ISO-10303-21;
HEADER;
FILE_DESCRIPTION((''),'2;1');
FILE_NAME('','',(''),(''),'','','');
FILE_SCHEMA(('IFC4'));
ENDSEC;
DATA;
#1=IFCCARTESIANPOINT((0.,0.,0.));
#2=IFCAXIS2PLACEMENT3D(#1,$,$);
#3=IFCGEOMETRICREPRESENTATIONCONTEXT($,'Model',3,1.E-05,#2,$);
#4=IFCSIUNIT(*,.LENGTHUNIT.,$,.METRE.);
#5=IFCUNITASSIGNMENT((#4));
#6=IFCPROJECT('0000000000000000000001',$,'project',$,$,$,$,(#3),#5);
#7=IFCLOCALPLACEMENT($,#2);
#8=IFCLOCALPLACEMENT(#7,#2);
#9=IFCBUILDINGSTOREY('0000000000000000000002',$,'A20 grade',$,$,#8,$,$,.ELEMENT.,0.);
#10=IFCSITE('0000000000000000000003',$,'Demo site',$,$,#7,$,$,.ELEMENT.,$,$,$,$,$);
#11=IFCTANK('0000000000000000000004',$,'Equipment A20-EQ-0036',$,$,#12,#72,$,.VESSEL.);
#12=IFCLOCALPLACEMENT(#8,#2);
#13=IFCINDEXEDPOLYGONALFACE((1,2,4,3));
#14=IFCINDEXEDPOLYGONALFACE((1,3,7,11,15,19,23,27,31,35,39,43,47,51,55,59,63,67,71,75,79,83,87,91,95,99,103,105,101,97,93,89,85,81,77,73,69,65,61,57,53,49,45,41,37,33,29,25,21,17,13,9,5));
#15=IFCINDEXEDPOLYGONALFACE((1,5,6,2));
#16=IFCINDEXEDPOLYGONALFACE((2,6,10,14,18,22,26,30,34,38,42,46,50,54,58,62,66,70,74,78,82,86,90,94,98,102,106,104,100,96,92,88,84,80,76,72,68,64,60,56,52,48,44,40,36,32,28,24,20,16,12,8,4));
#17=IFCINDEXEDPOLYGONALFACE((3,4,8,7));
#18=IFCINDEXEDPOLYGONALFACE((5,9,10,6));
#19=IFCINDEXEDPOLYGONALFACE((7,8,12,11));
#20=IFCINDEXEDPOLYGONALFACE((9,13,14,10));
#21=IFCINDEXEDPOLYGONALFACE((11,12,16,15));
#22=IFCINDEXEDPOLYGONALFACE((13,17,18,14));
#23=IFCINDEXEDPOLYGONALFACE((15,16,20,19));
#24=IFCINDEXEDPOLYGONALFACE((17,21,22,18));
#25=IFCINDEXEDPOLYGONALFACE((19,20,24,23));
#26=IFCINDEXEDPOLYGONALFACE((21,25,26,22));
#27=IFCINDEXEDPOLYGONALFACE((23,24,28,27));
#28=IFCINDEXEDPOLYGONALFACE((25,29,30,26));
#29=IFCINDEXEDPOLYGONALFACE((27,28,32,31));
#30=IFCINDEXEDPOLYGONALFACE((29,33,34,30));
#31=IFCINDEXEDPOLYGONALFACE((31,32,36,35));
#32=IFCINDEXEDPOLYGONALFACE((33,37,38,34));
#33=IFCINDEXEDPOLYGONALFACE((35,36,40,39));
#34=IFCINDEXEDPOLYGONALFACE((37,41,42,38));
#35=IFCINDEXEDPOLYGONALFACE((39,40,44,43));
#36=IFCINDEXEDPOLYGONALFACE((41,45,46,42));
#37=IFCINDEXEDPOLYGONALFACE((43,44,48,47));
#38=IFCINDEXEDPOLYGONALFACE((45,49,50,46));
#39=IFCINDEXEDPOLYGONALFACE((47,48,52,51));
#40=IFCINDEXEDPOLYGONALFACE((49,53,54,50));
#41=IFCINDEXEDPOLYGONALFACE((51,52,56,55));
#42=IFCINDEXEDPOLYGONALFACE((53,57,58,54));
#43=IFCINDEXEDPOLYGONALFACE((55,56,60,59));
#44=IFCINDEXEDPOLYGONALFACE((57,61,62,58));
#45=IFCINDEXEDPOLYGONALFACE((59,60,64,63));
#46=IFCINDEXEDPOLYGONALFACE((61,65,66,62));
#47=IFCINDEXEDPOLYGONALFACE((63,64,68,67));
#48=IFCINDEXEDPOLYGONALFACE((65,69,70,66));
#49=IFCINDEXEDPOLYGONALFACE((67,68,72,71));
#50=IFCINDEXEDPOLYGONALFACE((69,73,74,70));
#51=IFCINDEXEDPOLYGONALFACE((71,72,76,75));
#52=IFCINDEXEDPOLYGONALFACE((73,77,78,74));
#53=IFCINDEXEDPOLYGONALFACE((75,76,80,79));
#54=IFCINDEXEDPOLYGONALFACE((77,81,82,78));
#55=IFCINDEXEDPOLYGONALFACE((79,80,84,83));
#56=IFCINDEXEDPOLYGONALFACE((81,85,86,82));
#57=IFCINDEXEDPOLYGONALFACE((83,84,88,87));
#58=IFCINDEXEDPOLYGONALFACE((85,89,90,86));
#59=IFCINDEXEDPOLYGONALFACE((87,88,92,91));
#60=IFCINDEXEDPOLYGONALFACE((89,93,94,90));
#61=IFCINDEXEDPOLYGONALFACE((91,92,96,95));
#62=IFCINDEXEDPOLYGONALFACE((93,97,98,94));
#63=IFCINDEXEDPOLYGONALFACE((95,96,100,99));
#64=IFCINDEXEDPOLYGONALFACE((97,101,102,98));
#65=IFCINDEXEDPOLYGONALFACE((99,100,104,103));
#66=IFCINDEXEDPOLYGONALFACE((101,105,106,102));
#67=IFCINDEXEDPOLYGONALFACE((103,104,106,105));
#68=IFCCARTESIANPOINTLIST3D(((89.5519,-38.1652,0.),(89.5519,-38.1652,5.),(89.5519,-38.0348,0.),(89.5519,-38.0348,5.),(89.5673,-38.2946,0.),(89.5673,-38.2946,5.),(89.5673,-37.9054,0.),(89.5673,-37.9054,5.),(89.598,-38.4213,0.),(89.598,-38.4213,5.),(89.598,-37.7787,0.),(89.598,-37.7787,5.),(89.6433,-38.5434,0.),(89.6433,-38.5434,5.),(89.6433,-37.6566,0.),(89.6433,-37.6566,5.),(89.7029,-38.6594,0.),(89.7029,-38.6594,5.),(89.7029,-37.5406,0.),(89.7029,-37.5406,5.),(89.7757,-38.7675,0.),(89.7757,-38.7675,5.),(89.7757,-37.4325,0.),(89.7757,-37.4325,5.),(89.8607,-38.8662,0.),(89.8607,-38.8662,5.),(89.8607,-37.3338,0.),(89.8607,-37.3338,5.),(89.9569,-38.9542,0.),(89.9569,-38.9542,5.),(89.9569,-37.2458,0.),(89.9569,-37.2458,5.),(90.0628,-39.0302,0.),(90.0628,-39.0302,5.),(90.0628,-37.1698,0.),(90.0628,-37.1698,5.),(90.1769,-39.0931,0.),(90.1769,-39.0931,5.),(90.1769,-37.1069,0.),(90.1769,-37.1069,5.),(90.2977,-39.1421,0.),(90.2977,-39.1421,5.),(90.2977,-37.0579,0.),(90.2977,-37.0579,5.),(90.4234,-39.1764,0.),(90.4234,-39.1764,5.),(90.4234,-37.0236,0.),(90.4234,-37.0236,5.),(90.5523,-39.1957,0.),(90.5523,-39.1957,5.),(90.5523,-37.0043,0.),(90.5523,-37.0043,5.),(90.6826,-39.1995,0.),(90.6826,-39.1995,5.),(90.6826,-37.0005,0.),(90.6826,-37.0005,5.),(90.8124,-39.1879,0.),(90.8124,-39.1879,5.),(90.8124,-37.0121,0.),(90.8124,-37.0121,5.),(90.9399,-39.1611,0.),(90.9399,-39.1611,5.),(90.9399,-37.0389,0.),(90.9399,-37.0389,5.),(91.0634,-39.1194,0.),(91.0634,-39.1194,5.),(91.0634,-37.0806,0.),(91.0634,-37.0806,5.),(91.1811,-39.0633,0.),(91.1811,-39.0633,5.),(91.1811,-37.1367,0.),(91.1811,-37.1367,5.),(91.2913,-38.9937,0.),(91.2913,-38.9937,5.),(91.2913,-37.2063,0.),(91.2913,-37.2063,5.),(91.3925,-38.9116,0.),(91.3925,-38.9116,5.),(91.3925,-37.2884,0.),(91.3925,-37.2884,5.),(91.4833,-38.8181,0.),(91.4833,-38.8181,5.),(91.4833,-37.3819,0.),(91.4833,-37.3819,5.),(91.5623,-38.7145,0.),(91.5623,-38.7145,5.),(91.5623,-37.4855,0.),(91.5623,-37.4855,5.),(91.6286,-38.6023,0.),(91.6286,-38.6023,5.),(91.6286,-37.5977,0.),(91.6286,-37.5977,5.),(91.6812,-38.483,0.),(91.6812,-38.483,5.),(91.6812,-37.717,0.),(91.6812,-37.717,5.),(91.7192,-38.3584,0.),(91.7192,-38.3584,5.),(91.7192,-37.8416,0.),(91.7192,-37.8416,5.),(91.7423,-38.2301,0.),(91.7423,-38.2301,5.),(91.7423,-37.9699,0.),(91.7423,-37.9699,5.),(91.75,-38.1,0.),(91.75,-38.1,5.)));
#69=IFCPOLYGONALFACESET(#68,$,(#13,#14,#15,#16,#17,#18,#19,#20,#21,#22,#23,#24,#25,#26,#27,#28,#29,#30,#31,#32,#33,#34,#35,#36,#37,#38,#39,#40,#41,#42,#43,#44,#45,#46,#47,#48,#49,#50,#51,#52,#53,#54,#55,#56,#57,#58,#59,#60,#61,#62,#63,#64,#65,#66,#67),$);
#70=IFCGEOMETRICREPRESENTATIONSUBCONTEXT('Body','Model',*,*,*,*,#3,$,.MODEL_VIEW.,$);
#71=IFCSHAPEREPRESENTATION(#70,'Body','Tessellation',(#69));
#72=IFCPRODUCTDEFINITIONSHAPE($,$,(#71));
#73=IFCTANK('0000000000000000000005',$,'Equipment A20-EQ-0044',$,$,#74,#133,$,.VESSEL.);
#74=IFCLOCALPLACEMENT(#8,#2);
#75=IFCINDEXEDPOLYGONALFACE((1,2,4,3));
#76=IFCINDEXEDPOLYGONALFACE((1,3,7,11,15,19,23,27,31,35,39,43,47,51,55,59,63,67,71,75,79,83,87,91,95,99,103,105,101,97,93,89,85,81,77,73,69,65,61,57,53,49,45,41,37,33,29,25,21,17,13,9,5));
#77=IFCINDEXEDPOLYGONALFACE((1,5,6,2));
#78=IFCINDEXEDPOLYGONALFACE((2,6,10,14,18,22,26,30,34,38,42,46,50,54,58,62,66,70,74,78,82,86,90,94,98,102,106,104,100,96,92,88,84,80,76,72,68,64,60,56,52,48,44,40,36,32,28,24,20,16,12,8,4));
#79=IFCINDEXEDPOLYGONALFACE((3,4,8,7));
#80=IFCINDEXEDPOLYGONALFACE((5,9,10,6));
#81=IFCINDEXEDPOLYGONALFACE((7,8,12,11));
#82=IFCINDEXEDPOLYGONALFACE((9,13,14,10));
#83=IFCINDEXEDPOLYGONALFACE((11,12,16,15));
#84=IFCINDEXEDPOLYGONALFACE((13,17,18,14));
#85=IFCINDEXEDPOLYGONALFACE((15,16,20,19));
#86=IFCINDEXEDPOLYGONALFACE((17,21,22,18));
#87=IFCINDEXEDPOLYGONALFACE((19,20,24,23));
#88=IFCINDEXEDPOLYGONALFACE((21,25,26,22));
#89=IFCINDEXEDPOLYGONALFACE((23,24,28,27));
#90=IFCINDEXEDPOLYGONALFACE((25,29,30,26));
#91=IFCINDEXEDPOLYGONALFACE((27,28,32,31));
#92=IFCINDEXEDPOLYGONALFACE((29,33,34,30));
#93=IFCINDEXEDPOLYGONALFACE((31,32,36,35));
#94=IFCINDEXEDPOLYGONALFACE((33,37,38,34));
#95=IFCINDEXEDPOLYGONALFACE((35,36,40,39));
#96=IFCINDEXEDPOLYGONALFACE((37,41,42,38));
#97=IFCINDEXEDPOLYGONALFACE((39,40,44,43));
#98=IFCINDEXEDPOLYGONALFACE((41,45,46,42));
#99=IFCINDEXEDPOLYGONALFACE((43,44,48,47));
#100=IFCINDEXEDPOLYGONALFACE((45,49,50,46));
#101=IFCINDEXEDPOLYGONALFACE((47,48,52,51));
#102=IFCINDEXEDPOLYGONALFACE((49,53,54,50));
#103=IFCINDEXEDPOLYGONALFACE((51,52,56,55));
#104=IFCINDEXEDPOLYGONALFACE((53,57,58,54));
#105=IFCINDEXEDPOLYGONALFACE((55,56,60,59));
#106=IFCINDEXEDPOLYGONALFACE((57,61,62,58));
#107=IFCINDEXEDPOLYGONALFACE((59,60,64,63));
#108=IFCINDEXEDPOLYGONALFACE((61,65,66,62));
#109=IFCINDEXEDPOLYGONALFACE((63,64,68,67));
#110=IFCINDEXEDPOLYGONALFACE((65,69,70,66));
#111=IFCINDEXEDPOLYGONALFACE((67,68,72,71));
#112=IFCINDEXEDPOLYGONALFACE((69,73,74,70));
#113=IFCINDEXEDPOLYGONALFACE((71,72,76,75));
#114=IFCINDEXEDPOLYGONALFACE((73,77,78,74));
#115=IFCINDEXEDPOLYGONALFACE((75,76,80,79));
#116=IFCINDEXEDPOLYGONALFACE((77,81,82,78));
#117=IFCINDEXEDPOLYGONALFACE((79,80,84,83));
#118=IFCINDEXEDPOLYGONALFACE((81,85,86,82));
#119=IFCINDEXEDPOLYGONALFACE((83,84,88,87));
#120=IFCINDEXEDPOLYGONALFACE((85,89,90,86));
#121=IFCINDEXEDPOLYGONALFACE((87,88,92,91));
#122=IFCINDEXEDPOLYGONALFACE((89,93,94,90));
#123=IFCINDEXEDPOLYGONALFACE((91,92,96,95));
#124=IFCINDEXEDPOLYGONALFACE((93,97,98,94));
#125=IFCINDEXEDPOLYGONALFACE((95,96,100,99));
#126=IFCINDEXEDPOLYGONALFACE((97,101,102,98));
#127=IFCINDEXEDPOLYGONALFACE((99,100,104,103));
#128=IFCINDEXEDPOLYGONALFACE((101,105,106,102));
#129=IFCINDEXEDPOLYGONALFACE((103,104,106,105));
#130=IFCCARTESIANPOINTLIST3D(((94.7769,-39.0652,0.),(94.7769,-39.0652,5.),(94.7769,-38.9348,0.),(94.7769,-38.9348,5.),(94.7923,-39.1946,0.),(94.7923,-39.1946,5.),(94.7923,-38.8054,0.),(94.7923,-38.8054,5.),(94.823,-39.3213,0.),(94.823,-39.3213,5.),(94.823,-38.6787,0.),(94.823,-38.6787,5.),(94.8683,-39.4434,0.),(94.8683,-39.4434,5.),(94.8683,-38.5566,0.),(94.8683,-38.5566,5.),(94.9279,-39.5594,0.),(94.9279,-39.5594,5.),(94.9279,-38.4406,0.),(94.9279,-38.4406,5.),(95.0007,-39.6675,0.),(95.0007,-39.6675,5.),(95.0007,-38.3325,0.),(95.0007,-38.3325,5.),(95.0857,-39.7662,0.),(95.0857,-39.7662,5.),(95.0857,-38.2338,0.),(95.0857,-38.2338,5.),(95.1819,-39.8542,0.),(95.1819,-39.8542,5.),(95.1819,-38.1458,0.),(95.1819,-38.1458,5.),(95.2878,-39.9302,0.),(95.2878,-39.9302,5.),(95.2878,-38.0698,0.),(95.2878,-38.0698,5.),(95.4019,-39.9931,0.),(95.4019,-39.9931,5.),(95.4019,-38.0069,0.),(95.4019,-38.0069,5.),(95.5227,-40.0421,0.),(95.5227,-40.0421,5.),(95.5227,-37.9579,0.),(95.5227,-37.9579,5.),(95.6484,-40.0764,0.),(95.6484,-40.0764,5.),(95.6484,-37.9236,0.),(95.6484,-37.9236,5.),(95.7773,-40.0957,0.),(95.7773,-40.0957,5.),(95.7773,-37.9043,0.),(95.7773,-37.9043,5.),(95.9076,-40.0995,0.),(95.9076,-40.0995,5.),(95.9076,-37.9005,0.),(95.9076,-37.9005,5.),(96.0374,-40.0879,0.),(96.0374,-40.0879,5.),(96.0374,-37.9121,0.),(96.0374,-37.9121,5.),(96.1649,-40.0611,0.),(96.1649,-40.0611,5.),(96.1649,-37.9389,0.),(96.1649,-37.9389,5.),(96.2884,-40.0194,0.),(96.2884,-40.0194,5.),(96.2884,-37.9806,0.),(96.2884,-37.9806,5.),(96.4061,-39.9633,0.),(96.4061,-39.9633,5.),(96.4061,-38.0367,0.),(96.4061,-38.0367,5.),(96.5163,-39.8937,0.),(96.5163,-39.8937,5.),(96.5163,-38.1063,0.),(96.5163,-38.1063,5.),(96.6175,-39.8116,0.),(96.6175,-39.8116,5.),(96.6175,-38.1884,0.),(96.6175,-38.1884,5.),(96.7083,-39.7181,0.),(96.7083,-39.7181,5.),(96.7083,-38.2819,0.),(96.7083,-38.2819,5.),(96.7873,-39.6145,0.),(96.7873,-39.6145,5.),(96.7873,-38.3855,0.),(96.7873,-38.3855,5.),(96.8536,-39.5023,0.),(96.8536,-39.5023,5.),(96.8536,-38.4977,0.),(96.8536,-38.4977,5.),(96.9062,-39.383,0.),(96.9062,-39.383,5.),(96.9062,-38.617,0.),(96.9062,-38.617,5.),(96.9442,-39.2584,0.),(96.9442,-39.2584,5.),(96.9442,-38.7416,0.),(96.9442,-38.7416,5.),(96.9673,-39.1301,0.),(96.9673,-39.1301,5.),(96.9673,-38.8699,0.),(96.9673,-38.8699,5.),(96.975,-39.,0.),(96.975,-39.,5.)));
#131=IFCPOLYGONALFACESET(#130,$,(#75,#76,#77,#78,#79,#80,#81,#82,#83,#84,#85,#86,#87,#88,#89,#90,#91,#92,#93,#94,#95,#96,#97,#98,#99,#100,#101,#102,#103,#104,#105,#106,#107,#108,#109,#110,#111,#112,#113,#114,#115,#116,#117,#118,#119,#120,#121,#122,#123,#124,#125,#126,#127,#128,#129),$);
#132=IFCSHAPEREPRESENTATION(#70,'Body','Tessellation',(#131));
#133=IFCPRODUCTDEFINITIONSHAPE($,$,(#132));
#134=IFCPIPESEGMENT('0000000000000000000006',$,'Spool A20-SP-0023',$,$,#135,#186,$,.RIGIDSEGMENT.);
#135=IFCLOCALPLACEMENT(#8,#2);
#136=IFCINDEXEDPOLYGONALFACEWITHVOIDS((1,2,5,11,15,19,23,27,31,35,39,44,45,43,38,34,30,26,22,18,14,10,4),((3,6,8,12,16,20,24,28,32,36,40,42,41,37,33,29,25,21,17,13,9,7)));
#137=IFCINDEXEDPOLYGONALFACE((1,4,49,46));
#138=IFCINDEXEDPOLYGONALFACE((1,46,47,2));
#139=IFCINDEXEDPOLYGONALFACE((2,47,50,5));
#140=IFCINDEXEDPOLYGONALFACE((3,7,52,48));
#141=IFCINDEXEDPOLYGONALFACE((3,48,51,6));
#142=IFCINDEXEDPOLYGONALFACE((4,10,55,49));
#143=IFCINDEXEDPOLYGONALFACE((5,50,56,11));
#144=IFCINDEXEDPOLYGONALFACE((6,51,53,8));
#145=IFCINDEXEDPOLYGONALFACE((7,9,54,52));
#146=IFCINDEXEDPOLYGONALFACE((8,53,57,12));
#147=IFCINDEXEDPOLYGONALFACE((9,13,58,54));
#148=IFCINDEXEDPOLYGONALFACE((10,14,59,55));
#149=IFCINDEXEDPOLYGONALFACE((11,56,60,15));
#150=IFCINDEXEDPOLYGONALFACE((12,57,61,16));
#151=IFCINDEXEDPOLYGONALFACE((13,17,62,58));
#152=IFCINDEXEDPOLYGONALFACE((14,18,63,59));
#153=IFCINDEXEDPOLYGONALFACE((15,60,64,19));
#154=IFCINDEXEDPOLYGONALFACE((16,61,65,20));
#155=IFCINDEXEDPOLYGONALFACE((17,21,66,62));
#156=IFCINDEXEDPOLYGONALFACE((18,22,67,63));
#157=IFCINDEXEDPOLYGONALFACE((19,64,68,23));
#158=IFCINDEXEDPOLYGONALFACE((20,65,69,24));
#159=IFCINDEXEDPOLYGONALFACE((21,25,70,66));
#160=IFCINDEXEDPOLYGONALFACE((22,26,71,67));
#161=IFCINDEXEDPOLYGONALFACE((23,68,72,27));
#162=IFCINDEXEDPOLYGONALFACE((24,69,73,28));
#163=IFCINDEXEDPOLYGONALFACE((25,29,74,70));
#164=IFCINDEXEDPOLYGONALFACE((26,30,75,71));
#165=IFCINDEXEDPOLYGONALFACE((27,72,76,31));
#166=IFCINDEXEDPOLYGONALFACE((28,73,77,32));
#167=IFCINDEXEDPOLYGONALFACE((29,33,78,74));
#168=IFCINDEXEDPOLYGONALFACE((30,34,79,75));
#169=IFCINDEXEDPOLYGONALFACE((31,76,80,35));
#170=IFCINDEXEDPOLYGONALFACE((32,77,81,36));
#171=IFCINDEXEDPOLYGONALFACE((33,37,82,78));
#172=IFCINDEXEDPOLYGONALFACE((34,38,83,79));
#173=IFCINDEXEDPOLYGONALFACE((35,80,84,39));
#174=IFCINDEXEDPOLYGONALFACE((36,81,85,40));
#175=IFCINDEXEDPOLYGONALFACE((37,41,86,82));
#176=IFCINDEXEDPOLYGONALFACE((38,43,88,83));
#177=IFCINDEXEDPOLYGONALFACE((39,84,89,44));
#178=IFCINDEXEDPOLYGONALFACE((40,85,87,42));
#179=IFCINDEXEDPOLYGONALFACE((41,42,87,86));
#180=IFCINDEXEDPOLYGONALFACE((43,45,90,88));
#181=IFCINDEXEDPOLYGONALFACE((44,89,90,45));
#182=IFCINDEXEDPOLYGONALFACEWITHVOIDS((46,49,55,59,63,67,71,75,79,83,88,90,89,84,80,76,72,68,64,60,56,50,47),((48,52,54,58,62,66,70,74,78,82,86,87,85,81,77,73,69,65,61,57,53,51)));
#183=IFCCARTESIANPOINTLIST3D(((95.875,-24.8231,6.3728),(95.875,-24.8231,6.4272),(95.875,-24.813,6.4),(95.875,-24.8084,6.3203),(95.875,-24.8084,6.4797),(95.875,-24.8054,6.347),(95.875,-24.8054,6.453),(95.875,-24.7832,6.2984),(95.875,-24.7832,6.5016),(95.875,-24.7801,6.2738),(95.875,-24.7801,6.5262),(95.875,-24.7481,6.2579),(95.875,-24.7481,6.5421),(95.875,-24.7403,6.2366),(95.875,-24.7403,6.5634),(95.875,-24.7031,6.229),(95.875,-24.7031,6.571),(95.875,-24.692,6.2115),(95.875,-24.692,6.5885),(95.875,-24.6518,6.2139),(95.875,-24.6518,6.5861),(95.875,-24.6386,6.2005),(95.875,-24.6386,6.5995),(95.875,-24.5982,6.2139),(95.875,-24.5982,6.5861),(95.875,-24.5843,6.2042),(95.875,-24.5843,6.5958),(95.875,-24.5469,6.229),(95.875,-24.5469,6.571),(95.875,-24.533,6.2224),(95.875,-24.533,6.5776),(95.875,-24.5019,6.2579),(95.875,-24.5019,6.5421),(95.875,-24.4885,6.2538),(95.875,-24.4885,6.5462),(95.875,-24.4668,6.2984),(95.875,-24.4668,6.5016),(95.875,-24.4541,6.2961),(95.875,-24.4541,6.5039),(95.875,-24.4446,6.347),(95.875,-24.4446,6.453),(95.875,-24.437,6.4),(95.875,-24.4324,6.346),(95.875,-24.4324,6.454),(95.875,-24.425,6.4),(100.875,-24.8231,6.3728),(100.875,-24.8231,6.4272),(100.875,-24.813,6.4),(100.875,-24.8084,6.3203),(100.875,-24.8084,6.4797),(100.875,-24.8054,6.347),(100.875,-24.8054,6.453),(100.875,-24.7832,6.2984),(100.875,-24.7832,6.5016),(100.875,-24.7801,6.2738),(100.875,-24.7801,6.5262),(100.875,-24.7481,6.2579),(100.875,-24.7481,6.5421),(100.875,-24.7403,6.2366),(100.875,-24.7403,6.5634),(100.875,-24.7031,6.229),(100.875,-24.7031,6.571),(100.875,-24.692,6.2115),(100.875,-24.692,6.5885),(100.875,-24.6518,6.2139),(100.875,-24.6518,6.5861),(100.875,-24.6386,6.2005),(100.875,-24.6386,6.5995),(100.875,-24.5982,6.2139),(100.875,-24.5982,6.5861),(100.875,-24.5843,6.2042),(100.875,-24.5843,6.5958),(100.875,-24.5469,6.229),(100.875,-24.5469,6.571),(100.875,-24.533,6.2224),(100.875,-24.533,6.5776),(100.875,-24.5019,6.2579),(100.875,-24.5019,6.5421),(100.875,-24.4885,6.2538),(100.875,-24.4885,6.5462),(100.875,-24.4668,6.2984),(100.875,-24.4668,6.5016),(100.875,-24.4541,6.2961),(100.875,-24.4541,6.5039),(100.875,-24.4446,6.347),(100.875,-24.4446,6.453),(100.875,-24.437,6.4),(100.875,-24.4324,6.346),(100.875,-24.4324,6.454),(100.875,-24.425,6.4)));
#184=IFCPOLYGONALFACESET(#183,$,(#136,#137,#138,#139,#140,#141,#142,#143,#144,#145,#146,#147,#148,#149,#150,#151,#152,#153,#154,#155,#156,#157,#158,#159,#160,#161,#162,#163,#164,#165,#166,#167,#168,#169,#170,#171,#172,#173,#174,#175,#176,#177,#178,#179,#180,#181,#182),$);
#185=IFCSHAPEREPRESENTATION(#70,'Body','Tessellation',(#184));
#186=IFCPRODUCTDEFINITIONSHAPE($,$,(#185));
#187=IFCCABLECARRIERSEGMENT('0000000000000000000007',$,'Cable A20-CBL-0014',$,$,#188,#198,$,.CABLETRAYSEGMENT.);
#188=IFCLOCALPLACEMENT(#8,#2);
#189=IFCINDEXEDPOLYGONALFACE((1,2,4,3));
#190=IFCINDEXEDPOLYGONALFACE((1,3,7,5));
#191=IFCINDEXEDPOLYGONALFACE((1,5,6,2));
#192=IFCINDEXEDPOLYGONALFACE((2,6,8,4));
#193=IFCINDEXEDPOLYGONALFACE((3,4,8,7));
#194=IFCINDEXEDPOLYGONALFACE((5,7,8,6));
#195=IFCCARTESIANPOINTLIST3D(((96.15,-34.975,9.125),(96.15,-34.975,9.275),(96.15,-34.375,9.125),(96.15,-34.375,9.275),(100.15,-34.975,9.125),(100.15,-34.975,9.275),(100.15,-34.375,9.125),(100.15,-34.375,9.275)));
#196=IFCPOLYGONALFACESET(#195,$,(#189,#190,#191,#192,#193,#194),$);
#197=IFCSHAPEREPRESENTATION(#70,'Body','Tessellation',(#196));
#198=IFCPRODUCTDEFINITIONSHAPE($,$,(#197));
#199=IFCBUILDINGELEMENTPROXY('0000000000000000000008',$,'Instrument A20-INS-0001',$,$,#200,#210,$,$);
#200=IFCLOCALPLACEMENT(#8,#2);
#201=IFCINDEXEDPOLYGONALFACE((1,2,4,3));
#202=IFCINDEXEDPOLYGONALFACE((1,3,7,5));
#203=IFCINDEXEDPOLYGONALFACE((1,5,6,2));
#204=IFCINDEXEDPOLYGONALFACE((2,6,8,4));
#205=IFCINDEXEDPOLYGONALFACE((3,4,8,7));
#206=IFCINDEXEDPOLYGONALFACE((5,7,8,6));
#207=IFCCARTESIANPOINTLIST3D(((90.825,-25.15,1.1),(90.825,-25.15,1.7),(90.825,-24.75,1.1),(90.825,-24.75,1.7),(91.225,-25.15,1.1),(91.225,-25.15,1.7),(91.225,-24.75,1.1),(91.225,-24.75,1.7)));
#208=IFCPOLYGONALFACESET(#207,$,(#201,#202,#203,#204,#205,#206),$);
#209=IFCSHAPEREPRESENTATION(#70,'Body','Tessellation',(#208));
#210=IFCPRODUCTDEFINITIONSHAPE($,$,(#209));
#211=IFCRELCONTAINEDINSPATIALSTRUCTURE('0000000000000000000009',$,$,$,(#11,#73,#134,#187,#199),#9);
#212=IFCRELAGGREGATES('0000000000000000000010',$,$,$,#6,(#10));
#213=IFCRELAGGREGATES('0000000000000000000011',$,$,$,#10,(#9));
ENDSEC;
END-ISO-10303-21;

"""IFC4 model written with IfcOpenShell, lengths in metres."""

from ifc_helpers import new_model, si_unit, frame, origin, place, context, subcontext, project, spatial, rectangle, circle, hollow_circle, extrude, element, save


model = new_model("IFC4")

# Units and contexts
model_context = context("Model", 3, precision=1e-05, world=origin())
body_context = subcontext(model_context, "Body", "Model", "MODEL_VIEW")
ifc_project = project(units=[si_unit("LENGTHUNIT", "METRE")], contexts=[model_context])

# Site, storey
site_placement = place(None, origin())
site = spatial("IfcSite", under=ifc_project, at=site_placement, Name="Demo site", CompositionType="ELEMENT")
storey_placement = place(site_placement, origin())
storey = spatial("IfcBuildingStorey", under=site, at=storey_placement, Name="A20 grade", CompositionType="ELEMENT", Elevation=0.0)

# Tanks
for number, where, name in (
    (1, (90.65, -38.1, 0.0), "Equipment A20-EQ-0036"),
    (2, (95.875, -39.0, 0.0), "Equipment A20-EQ-0044"),
):
    element("IfcTank", number, at=place(storey_placement, frame(where)), inside=storey, Name=name, PredefinedType="VESSEL", context=body_context, shape_type="SweptSolid", body=[
        extrude(circle(Radius=1.1), origin(), (0.0, 0.0, 1.0), 5.0),
    ])

# Pipe segment
pipe_segment_placement = place(storey_placement, frame((95.875, -24.625, 6.4)))
element("IfcPipeSegment", 3, at=pipe_segment_placement, inside=storey, Name="Spool A20-SP-0023", PredefinedType="RIGIDSEGMENT", context=body_context, shape_type="SweptSolid", body=[
    extrude(hollow_circle(Radius=0.2, WallThickness=0.012), frame((0.0, 0.0, 0.0), z_axis=(1.0, 0.0, 0.0), x_axis=(0.0, 1.0, 0.0)), (0.0, 0.0, 1.0), 5.0),
])

# Cable carrier segment
cable_carrier_segment_1_placement = place(storey_placement, frame((96.15, -34.675, 9.2)))
element("IfcCableCarrierSegment", 4, at=cable_carrier_segment_1_placement, inside=storey, Name="Cable A20-CBL-0014", PredefinedType="CABLETRAYSEGMENT", context=body_context, shape_type="SweptSolid", body=[
    extrude(rectangle(XDim=0.6, YDim=0.15), frame((0.0, 0.0, 0.0), z_axis=(1.0, 0.0, 0.0), x_axis=(0.0, 1.0, 0.0)), (0.0, 0.0, 1.0), 4.0),
])

# Building element proxy
for number, where, name in (
    (5, (91.025, -24.95, 1.1), "Instrument A20-INS-0001"),
):
    element("IfcBuildingElementProxy", number, at=place(storey_placement, frame(where)), inside=storey, Name=name, context=body_context, shape_type="SweptSolid", body=[
        extrude(rectangle(XDim=0.4, YDim=0.4), origin(), (0.0, 0.0, 1.0), 0.6),
    ])

save(model, "model.ifc")
